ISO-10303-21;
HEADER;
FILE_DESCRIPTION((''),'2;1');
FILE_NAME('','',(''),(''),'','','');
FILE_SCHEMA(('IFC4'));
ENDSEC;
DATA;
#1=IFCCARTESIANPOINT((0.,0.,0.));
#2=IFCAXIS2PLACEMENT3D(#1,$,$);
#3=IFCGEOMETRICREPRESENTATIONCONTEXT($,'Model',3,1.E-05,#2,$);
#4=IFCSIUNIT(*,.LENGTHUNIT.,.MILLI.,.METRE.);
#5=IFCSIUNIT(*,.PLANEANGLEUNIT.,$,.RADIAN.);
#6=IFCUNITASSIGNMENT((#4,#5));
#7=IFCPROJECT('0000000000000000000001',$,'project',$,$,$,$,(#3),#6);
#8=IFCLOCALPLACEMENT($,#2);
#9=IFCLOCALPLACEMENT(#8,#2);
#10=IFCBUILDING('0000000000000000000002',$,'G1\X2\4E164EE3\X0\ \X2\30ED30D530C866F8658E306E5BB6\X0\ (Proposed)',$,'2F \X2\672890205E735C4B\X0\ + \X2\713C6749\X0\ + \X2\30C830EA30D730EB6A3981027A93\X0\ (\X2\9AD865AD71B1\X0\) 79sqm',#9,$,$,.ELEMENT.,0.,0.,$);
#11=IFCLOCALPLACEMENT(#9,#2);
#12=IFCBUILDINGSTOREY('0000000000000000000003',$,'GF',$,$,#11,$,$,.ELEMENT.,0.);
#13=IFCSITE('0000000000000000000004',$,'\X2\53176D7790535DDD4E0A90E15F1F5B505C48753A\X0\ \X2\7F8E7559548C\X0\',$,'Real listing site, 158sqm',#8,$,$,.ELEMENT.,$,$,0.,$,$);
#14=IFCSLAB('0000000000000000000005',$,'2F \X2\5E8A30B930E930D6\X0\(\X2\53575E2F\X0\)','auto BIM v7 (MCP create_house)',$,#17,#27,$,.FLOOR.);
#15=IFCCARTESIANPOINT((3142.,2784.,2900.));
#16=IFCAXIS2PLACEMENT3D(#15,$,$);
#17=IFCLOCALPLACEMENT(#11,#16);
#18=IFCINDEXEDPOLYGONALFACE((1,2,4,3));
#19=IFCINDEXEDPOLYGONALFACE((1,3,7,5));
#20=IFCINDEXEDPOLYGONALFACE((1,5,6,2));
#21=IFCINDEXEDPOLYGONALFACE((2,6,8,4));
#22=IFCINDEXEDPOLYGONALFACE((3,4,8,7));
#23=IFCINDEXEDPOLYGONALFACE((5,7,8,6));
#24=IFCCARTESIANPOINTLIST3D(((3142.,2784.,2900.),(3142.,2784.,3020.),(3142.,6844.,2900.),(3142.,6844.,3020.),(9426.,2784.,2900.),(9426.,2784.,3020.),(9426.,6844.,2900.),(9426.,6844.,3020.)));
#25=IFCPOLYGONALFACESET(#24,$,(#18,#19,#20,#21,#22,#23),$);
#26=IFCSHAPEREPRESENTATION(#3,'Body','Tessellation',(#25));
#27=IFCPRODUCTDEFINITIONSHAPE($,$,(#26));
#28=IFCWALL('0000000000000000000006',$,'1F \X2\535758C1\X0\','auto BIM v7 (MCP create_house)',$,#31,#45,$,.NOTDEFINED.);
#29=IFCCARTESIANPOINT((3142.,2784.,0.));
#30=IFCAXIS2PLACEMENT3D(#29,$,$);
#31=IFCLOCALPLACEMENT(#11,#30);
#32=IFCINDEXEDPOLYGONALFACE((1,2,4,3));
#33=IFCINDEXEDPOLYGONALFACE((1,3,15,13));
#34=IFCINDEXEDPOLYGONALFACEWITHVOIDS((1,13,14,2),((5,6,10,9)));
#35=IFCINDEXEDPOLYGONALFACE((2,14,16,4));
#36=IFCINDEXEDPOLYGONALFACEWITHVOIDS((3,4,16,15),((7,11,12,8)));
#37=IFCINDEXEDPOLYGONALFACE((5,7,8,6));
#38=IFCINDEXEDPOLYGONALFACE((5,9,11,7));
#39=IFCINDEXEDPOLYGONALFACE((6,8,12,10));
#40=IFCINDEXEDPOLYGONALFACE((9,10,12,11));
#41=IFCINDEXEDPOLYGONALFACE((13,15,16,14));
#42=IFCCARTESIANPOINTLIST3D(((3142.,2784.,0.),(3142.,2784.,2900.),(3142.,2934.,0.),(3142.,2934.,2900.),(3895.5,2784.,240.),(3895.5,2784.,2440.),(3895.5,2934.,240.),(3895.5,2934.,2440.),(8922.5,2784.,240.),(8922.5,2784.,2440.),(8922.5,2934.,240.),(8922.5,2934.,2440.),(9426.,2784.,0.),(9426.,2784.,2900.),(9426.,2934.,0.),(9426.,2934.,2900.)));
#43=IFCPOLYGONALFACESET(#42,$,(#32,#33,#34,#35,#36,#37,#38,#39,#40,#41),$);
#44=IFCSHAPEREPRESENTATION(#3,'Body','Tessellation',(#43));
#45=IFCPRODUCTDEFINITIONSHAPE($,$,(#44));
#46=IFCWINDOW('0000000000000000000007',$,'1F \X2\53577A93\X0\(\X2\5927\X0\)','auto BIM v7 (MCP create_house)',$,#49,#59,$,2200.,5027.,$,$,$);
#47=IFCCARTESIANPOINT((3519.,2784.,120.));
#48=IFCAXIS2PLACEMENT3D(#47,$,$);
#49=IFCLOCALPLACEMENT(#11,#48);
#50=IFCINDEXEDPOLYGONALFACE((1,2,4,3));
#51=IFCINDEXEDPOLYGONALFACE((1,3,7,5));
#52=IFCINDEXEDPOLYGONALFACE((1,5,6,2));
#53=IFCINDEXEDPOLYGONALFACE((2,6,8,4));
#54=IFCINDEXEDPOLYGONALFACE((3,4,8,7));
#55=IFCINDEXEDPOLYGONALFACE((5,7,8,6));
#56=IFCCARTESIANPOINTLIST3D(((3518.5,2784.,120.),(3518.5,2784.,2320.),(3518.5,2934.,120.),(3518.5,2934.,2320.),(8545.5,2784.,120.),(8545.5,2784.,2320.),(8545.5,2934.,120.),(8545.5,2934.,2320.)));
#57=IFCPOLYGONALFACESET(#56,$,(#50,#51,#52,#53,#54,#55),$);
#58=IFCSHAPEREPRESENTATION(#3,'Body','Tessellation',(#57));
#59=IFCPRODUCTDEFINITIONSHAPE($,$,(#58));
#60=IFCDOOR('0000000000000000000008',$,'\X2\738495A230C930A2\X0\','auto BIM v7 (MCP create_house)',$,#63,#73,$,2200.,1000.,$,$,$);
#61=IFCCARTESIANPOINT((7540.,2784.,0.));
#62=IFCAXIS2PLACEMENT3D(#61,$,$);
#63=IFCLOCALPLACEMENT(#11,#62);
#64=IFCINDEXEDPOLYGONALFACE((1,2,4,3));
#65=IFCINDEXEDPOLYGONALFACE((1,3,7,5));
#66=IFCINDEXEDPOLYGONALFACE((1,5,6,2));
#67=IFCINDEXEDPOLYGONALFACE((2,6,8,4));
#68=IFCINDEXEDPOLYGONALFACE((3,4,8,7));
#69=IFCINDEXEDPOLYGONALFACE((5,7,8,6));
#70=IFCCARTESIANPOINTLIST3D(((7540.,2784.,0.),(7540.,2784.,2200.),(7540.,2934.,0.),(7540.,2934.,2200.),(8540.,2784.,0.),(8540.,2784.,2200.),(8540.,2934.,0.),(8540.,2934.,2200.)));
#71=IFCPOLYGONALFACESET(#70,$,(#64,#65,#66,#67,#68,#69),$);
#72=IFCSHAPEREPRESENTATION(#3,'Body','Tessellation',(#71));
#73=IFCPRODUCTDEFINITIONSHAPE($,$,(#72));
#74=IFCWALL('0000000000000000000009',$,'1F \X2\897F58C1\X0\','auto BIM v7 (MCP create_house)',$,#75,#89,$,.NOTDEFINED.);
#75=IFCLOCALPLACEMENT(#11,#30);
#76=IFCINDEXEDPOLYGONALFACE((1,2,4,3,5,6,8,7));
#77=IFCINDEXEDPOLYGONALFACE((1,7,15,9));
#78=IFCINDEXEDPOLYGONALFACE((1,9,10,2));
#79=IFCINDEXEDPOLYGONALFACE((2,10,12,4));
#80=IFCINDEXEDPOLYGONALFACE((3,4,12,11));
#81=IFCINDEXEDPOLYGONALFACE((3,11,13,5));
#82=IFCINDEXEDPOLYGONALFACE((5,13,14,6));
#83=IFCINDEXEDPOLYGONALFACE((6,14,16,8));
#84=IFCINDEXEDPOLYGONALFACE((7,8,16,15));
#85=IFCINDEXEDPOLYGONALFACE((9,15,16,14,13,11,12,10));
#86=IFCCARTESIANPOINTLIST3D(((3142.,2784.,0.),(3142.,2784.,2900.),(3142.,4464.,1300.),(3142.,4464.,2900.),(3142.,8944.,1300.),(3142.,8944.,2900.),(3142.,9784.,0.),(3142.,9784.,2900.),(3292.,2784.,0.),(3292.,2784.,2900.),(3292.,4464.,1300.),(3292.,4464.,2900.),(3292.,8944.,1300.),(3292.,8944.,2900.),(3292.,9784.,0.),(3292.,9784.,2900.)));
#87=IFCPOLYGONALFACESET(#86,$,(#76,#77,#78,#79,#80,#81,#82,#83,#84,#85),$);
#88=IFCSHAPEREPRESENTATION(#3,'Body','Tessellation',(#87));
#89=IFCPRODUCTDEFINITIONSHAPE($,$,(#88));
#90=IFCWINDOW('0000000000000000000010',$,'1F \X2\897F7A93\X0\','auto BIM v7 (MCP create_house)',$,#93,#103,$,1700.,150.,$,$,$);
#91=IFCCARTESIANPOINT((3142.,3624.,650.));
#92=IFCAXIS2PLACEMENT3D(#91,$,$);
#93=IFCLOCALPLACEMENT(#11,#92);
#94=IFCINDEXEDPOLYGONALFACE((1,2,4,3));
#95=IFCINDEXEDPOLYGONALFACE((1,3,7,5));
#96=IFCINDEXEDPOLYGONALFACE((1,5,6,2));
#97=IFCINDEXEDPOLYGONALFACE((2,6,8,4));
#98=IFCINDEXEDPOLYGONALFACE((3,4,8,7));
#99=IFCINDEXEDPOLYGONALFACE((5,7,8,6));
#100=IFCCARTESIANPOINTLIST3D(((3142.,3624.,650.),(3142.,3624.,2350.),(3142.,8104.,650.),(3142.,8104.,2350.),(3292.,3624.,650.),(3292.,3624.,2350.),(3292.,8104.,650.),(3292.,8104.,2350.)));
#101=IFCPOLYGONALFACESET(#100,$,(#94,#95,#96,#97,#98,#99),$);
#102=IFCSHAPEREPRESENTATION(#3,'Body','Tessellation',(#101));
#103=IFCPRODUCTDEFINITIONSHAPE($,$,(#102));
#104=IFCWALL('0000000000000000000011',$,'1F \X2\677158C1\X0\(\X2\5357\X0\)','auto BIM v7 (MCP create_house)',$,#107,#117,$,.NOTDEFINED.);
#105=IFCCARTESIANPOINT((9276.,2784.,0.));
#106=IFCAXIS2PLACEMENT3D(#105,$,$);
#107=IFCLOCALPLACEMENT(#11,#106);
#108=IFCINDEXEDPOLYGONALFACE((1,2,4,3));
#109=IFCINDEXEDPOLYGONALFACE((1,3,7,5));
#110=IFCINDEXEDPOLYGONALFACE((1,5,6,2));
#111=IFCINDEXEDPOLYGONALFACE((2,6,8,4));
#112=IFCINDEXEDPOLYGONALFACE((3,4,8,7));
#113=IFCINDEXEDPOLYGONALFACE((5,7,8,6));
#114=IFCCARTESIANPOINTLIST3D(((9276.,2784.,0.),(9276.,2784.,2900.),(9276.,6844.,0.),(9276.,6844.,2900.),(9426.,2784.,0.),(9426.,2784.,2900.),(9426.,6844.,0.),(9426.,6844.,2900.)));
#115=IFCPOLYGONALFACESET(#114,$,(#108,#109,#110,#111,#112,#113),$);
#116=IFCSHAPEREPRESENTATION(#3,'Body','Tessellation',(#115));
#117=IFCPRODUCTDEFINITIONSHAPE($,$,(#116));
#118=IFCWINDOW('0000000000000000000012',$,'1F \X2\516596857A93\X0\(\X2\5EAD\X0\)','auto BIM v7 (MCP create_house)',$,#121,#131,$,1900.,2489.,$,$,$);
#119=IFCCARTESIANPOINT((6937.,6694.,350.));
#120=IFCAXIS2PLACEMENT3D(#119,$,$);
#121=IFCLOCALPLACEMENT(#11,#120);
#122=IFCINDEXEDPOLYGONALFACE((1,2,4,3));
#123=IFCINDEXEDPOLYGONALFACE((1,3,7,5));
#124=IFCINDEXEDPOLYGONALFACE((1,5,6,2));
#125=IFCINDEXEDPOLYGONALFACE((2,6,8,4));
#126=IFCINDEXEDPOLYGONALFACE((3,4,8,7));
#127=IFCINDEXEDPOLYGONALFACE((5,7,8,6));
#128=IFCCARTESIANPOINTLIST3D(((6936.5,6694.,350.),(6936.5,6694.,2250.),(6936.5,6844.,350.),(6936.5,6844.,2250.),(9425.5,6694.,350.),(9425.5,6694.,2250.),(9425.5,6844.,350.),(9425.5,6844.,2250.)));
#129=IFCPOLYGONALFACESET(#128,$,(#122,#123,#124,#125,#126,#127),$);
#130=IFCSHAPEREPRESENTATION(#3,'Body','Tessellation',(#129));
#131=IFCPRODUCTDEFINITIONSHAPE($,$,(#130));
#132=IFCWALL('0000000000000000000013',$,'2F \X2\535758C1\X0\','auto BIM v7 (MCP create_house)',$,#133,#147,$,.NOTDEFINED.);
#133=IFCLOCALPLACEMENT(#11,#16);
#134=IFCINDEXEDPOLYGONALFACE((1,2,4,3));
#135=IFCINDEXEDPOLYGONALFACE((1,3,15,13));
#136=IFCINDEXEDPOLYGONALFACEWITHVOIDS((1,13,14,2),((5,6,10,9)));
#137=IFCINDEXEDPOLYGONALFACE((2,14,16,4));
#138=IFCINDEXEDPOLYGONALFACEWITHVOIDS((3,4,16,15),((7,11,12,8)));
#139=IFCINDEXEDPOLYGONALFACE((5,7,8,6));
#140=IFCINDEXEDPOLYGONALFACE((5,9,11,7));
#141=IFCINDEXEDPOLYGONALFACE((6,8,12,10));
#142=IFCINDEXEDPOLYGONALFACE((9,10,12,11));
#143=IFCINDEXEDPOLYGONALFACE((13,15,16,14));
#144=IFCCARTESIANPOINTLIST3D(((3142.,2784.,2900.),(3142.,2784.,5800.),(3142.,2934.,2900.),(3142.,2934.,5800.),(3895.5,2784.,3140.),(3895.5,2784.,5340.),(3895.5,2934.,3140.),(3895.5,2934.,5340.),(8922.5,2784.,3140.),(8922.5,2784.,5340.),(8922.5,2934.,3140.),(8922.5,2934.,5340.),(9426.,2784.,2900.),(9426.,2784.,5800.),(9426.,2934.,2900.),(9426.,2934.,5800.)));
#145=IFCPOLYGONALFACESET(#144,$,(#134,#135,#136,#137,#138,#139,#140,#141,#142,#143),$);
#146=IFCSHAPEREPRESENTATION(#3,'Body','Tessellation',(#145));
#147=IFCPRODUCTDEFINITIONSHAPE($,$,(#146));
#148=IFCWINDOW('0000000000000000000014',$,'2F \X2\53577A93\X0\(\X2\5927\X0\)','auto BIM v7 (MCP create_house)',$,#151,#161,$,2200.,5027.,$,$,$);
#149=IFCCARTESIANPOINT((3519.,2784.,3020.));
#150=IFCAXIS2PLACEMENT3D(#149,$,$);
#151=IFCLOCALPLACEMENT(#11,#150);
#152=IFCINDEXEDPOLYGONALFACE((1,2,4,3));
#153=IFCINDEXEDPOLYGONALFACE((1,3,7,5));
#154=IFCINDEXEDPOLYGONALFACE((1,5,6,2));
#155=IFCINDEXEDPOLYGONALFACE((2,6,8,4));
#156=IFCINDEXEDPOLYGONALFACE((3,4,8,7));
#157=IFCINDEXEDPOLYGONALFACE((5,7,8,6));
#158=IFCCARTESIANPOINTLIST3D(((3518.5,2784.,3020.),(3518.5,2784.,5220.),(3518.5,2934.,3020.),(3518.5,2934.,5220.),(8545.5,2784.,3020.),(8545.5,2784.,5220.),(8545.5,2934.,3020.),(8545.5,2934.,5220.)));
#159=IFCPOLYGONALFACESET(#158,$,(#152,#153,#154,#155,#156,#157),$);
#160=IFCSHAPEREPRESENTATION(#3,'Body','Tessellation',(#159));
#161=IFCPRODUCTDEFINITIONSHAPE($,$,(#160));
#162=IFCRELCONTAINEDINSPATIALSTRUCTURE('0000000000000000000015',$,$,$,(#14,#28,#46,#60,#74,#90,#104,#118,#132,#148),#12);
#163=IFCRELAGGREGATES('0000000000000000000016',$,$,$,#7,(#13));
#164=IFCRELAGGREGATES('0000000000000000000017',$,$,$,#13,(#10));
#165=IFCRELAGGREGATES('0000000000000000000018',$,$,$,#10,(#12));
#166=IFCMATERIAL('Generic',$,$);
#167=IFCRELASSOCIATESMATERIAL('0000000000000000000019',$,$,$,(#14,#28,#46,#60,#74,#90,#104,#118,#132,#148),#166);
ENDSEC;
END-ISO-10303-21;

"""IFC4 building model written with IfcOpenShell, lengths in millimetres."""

from ifc_helpers import new_model, si_unit, frame, frame_2d, origin, place, context, project, spatial, rectangle, extrude, material, element, fill, save


model = new_model("IFC4")

# Units and contexts
model_context = context("Model", 3, precision=1e-05, world=origin())
ifc_project = project(units=[si_unit("LENGTHUNIT", "METRE", prefix="MILLI"), si_unit("PLANEANGLEUNIT", "RADIAN")], contexts=[model_context])

# Site, building, storey
site_placement = place(None, origin())
site = spatial("IfcSite", under=ifc_project, at=site_placement, Name="北海道川上郡弟子屈町 美留和", ObjectType="Real listing site, 158sqm", CompositionType="ELEMENT", RefElevation=0.0)
building_placement = place(site_placement, origin())
building = spatial("IfcBuilding", under=site, at=building_placement, Name="G1世代 ロフト書斎の家 (Proposed)", ObjectType="2F 木造平屋 + 焼杉 + トリプル樹脂窓 (高断熱) 79sqm", CompositionType="ELEMENT", ElevationOfRefHeight=0.0, ElevationOfTerrain=0.0)
storey_placement = place(building_placement, origin())
storey = spatial("IfcBuildingStorey", under=building, at=storey_placement, Name="GF", CompositionType="ELEMENT", Elevation=0.0)

# Slab
ifc_material = material(Name="Generic")
slab_1_placement = place(storey_placement, frame((3142.0, 2784.0, 2900.0)))
element("IfcSlab", 1, at=slab_1_placement, inside=storey, material=ifc_material, Name="2F 床スラブ(南帯)", Description="auto BIM v7 (MCP create_house)", PredefinedType="FLOOR", context=model_context, shape_type="SweptSolid", body=[
    extrude(rectangle(XDim=6284.0, YDim=4060.0, at=frame_2d((3142.0, 2030.0))), frame((3142.0, 2784.0, 2900.0)), (0.0, 0.0, 1.0), 120.0),
])

# Wall, openings, window, door
wall_1_placement = place(storey_placement, frame((3142.0, 2784.0, 0.0)))
wall_1 = element("IfcWall", 2, at=wall_1_placement, inside=storey, material=ifc_material, Name="1F 南壁", Description="auto BIM v7 (MCP create_house)", PredefinedType="NOTDEFINED", context=model_context, shape_type="SweptSolid", body=[
    extrude(rectangle(XDim=6284.0, YDim=150.0, at=frame_2d((3142.0, 75.0))), frame((3142.0, 2784.0, 0.0)), (0.0, 0.0, 1.0), 2900.0),
])
opening_1_placement = place(storey_placement, frame((3519.0, 2784.0, 120.0)))
opening_1 = element("IfcOpeningElement", 3, at=opening_1_placement, cuts=wall_1, PredefinedType="NOTDEFINED", context=model_context, shape_type="SweptSolid", body=[
    extrude(rectangle(XDim=5027.0, YDim=150.0, at=frame_2d((2513.0, 75.0))), frame((3519.0, 2784.0, 120.0)), (0.0, 0.0, 1.0), 2200.0),
])
opening_2_placement = place(storey_placement, frame((7540.0, 2784.0, 0.0)))
opening_2 = element("IfcOpeningElement", 4, at=opening_2_placement, cuts=wall_1, PredefinedType="NOTDEFINED", context=model_context, shape_type="SweptSolid", body=[
    extrude(rectangle(XDim=1000.0, YDim=150.0, at=frame_2d((500.0, 75.0))), frame((7540.0, 2784.0, 0.0)), (0.0, 0.0, 1.0), 2200.0),
])
window_1_placement = place(storey_placement, frame((3519.0, 2784.0, 120.0)))
window_1 = element("IfcWindow", 5, at=window_1_placement, inside=storey, material=ifc_material, Name="1F 南窓(大)", Description="auto BIM v7 (MCP create_house)", OverallHeight=2200.0, OverallWidth=5027.0, context=model_context, shape_type="SweptSolid", body=[
    extrude(rectangle(XDim=5027.0, YDim=150.0, at=frame_2d((2513.0, 75.0))), frame((3519.0, 2784.0, 120.0)), (0.0, 0.0, 1.0), 2200.0),
])
fill(opening_1, window_1)
door_placement = place(storey_placement, frame((7540.0, 2784.0, 0.0)))
door = element("IfcDoor", 6, at=door_placement, inside=storey, material=ifc_material, Name="玄関ドア", Description="auto BIM v7 (MCP create_house)", OverallHeight=2200.0, OverallWidth=1000.0, context=model_context, shape_type="SweptSolid", body=[
    extrude(rectangle(XDim=1000.0, YDim=150.0, at=frame_2d((500.0, 75.0))), frame((7540.0, 2784.0, 0.0)), (0.0, 0.0, 1.0), 2200.0),
])
fill(opening_2, door)

# Walls, openings, windows
wall_2_placement = place(storey_placement, frame((3142.0, 2784.0, 0.0)))
wall_2 = element("IfcWall", 7, at=wall_2_placement, inside=storey, material=ifc_material, Name="1F 西壁", Description="auto BIM v7 (MCP create_house)", PredefinedType="NOTDEFINED", context=model_context, shape_type="SweptSolid", body=[
    extrude(rectangle(XDim=150.0, YDim=7000.0, at=frame_2d((75.0, 3500.0))), frame((3142.0, 2784.0, 0.0)), (0.0, 0.0, 1.0), 2900.0),
])
opening_3_placement = place(storey_placement, frame((3142.0, 3624.0, 650.0)))
opening_3 = element("IfcOpeningElement", 8, at=opening_3_placement, cuts=wall_2, PredefinedType="NOTDEFINED", context=model_context, shape_type="SweptSolid", body=[
    extrude(rectangle(XDim=150.0, YDim=4480.0, at=frame_2d((75.0, 2240.0))), frame((3142.0, 3624.0, 650.0)), (0.0, 0.0, 1.0), 1700.0),
])
window_2_placement = place(storey_placement, frame((3142.0, 3624.0, 650.0)))
window_2 = element("IfcWindow", 9, at=window_2_placement, inside=storey, material=ifc_material, Name="1F 西窓", Description="auto BIM v7 (MCP create_house)", OverallHeight=1700.0, OverallWidth=150.0, context=model_context, shape_type="SweptSolid", body=[
    extrude(rectangle(XDim=150.0, YDim=4480.0, at=frame_2d((75.0, 2240.0))), frame((3142.0, 3624.0, 650.0)), (0.0, 0.0, 1.0), 1700.0),
])
fill(opening_3, window_2)
wall_3_placement = place(storey_placement, frame((9276.0, 2784.0, 0.0)))
wall_3 = element("IfcWall", 10, at=wall_3_placement, inside=storey, material=ifc_material, Name="1F 東壁(南)", Description="auto BIM v7 (MCP create_house)", PredefinedType="NOTDEFINED", context=model_context, shape_type="SweptSolid", body=[
    extrude(rectangle(XDim=150.0, YDim=4060.0, at=frame_2d((75.0, 2030.0))), frame((9276.0, 2784.0, 0.0)), (0.0, 0.0, 1.0), 2900.0),
])
opening_4_placement = place(storey_placement, frame((6937.0, 6694.0, 350.0)))
opening_4 = element("IfcOpeningElement", 11, at=opening_4_placement, cuts=wall_3, PredefinedType="NOTDEFINED", context=model_context, shape_type="SweptSolid", body=[
    extrude(rectangle(XDim=2489.0, YDim=150.0, at=frame_2d((1244.0, 75.0))), frame((6937.0, 6694.0, 350.0)), (0.0, 0.0, 1.0), 1900.0),
])
window_3_placement = place(storey_placement, frame((6937.0, 6694.0, 350.0)))
window_3 = element("IfcWindow", 12, at=window_3_placement, inside=storey, material=ifc_material, Name="1F 入隅窓(庭)", Description="auto BIM v7 (MCP create_house)", OverallHeight=1900.0, OverallWidth=2489.0, context=model_context, shape_type="SweptSolid", body=[
    extrude(rectangle(XDim=2489.0, YDim=150.0, at=frame_2d((1244.0, 75.0))), frame((6937.0, 6694.0, 350.0)), (0.0, 0.0, 1.0), 1900.0),
])
fill(opening_4, window_3)

# Wall, opening, window
wall_4_placement = place(storey_placement, frame((3142.0, 2784.0, 2900.0)))
wall_4 = element("IfcWall", 13, at=wall_4_placement, inside=storey, material=ifc_material, Name="2F 南壁", Description="auto BIM v7 (MCP create_house)", PredefinedType="NOTDEFINED", context=model_context, shape_type="SweptSolid", body=[
    extrude(rectangle(XDim=6284.0, YDim=150.0, at=frame_2d((3142.0, 75.0))), frame((3142.0, 2784.0, 2900.0)), (0.0, 0.0, 1.0), 2900.0),
])
opening_5_placement = place(storey_placement, frame((3519.0, 2784.0, 3020.0)))
opening_5 = element("IfcOpeningElement", 14, at=opening_5_placement, cuts=wall_4, PredefinedType="NOTDEFINED", context=model_context, shape_type="SweptSolid", body=[
    extrude(rectangle(XDim=5027.0, YDim=150.0, at=frame_2d((2513.0, 75.0))), frame((3519.0, 2784.0, 3020.0)), (0.0, 0.0, 1.0), 2200.0),
])
window_4_placement = place(storey_placement, frame((3519.0, 2784.0, 3020.0)))
window_4 = element("IfcWindow", 15, at=window_4_placement, inside=storey, material=ifc_material, Name="2F 南窓(大)", Description="auto BIM v7 (MCP create_house)", OverallHeight=2200.0, OverallWidth=5027.0, context=model_context, shape_type="SweptSolid", body=[
    extrude(rectangle(XDim=5027.0, YDim=150.0, at=frame_2d((2513.0, 75.0))), frame((3519.0, 2784.0, 3020.0)), (0.0, 0.0, 1.0), 2200.0),
])
fill(opening_5, window_4)

save(model, "model.ifc")
